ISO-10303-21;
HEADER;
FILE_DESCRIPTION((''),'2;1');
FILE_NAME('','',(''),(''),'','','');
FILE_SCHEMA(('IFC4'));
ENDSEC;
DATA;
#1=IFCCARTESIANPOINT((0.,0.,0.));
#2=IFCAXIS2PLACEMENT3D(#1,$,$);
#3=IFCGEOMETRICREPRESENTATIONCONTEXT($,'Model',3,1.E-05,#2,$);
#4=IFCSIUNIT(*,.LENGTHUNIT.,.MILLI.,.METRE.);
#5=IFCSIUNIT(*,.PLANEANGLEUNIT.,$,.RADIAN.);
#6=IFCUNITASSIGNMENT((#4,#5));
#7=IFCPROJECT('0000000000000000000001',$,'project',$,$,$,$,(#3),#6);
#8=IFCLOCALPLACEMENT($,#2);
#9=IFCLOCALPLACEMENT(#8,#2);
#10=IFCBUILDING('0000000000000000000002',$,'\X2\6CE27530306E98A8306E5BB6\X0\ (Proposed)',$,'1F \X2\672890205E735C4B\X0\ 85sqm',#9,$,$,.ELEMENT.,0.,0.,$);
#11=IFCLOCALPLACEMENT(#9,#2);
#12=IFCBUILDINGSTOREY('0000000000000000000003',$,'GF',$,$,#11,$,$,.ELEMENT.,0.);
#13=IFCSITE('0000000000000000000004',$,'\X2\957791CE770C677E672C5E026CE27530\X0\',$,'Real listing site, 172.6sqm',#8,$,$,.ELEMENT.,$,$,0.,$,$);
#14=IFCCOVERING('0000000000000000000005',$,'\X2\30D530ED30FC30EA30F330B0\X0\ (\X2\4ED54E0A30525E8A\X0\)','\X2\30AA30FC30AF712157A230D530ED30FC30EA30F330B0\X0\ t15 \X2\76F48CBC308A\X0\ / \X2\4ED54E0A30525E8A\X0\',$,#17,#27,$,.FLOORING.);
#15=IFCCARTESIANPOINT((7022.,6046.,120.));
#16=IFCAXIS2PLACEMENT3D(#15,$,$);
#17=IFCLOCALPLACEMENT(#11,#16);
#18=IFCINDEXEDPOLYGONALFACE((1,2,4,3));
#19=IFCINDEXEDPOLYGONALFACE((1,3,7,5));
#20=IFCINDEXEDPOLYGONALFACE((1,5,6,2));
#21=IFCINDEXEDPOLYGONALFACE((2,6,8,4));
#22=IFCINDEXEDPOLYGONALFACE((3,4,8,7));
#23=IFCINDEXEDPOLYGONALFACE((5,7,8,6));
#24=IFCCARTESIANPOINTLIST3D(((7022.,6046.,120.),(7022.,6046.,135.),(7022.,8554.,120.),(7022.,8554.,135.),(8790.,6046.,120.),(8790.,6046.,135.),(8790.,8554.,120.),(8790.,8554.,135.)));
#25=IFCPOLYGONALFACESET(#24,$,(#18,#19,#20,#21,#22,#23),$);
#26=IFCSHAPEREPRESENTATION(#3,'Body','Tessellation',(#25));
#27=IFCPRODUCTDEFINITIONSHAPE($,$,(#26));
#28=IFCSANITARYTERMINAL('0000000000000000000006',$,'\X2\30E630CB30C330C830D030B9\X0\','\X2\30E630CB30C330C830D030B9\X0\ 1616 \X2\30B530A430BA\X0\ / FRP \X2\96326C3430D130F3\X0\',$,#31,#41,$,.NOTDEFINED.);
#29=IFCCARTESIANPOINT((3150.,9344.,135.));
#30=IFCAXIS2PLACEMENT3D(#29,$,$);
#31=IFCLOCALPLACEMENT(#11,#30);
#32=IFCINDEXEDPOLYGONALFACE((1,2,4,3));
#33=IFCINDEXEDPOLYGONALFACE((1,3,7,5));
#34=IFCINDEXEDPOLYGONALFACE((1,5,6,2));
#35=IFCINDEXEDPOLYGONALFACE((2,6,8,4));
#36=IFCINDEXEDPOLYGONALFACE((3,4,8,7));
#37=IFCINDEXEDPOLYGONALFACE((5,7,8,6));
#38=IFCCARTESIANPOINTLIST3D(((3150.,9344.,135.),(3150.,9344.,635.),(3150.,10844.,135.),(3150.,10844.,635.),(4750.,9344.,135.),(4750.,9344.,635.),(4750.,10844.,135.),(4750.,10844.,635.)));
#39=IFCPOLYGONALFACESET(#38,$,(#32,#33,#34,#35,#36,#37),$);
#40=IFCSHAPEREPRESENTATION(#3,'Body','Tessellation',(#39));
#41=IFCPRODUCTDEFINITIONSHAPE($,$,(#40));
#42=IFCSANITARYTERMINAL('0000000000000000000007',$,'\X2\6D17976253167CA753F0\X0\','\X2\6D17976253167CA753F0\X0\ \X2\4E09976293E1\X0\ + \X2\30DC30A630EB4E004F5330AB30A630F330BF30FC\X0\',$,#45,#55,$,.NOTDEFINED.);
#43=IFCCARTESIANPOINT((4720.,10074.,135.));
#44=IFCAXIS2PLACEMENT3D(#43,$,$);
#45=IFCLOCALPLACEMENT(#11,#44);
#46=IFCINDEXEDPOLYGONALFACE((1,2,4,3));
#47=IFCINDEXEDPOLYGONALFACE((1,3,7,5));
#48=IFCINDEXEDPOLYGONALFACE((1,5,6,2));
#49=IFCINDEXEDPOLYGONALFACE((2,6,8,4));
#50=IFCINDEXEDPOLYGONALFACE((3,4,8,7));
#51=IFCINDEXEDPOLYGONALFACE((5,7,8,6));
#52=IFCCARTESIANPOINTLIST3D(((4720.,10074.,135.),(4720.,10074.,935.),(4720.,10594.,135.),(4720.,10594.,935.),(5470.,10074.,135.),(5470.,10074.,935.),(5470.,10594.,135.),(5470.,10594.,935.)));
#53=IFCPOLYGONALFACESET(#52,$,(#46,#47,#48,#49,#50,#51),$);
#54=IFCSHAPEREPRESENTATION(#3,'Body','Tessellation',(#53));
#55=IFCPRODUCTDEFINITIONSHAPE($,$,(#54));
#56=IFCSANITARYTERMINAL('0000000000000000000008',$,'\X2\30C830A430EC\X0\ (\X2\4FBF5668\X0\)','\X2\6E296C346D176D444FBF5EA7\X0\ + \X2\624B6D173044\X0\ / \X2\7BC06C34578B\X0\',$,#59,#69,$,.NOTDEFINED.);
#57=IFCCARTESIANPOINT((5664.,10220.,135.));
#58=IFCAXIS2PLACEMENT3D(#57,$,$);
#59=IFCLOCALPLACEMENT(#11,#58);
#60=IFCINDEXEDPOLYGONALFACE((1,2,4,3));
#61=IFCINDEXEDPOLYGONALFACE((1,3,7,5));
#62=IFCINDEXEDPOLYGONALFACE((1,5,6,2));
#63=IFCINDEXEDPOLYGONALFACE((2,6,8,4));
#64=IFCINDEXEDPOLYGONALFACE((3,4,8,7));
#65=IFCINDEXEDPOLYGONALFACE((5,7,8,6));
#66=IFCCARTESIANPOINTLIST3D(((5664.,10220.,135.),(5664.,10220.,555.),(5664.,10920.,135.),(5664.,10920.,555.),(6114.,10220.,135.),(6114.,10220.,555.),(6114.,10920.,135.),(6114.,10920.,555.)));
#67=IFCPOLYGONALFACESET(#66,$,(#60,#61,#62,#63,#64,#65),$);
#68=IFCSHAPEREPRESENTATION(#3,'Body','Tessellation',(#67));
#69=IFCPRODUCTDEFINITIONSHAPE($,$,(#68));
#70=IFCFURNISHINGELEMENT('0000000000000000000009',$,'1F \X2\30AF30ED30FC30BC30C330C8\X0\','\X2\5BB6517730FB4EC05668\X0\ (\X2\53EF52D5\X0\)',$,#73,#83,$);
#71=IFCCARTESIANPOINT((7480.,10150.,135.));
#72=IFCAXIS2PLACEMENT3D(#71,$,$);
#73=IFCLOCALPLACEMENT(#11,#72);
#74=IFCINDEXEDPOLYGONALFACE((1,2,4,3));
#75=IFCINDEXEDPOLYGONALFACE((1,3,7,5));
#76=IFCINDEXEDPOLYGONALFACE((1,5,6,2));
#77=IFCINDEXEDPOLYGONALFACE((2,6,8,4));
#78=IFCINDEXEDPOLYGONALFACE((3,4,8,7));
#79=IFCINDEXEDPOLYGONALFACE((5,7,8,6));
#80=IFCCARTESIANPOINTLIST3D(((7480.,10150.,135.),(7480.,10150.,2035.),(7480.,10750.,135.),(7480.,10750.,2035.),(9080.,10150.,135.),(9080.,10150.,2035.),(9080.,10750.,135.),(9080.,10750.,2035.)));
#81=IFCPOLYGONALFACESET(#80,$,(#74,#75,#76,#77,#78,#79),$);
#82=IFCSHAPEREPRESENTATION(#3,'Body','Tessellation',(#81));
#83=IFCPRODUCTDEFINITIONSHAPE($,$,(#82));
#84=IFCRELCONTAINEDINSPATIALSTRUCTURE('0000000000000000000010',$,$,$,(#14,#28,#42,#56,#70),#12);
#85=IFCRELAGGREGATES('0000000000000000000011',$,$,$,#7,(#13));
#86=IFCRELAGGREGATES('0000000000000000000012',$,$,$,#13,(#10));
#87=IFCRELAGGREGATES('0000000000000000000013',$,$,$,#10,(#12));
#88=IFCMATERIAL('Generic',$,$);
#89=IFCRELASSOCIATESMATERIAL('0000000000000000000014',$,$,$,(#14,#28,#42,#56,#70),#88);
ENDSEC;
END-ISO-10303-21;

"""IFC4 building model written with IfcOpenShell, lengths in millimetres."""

from ifc_helpers import new_model, si_unit, frame, frame_2d, origin, place, context, project, spatial, rectangle, extrude, material, element, save


model = new_model("IFC4")

# Units and contexts
model_context = context("Model", 3, precision=1e-05, world=origin())
ifc_project = project(units=[si_unit("LENGTHUNIT", "METRE", prefix="MILLI"), si_unit("PLANEANGLEUNIT", "RADIAN")], contexts=[model_context])

# Site, building, storey
site_placement = place(None, origin())
site = spatial("IfcSite", under=ifc_project, at=site_placement, Name="長野県松本市波田", ObjectType="Real listing site, 172.6sqm", CompositionType="ELEMENT", RefElevation=0.0)
building_placement = place(site_placement, origin())
building = spatial("IfcBuilding", under=site, at=building_placement, Name="波田の風の家 (Proposed)", ObjectType="1F 木造平屋 85sqm", CompositionType="ELEMENT", ElevationOfRefHeight=0.0, ElevationOfTerrain=0.0)
storey_placement = place(building_placement, origin())
storey = spatial("IfcBuildingStorey", under=building, at=storey_placement, Name="GF", CompositionType="ELEMENT", Elevation=0.0)

# Covering
ifc_material_1 = material(Name="Generic")
covering_1_placement = place(storey_placement, frame((7022.0, 6046.0, 120.0)))
element("IfcCovering", 1, at=covering_1_placement, inside=storey, material=ifc_material_1, Name="フローリング (仕上げ床)", Description="オーク無垢フローリング t15 直貼り / 仕上げ床", PredefinedType="FLOORING", context=model_context, shape_type="SweptSolid", body=[
    extrude(rectangle(XDim=1768.0, YDim=2508.0, at=frame_2d((884.0, 1254.0))), frame((7022.0, 6046.0, 120.0)), (0.0, 0.0, 1.0), 15.0),
])

# Sanitary terminals
sanitary_terminal_1_placement = place(storey_placement, frame((3150.0, 9344.0, 135.0)))
element("IfcSanitaryTerminal", 2, at=sanitary_terminal_1_placement, inside=storey, material=ifc_material_1, Name="ユニットバス", Description="ユニットバス 1616 サイズ / FRP 防水パン", PredefinedType="NOTDEFINED", context=model_context, shape_type="SweptSolid", body=[
    extrude(rectangle(XDim=1600.0, YDim=1500.0, at=frame_2d((800.0, 750.0))), frame((3150.0, 9344.0, 135.0)), (0.0, 0.0, 1.0), 500.0),
])
sanitary_terminal_2_placement = place(storey_placement, frame((4720.0, 10074.0, 135.0)))
element("IfcSanitaryTerminal", 3, at=sanitary_terminal_2_placement, inside=storey, material=ifc_material_1, Name="洗面化粧台", Description="洗面化粧台 三面鏡 + ボウル一体カウンター", PredefinedType="NOTDEFINED", context=model_context, shape_type="SweptSolid", body=[
    extrude(rectangle(XDim=750.0, YDim=520.0, at=frame_2d((375.0, 260.0))), frame((4720.0, 10074.0, 135.0)), (0.0, 0.0, 1.0), 800.0),
])
sanitary_terminal_3_placement = place(storey_placement, frame((5664.0, 10220.0, 135.0)))
element("IfcSanitaryTerminal", 4, at=sanitary_terminal_3_placement, inside=storey, material=ifc_material_1, Name="トイレ (便器)", Description="温水洗浄便座 + 手洗い / 節水型", PredefinedType="NOTDEFINED", context=model_context, shape_type="SweptSolid", body=[
    extrude(rectangle(XDim=450.0, YDim=700.0, at=frame_2d((225.0, 350.0))), frame((5664.0, 10220.0, 135.0)), (0.0, 0.0, 1.0), 420.0),
])

# Furnishing element
furnishing_placement = place(storey_placement, frame((7480.0, 10150.0, 135.0)))
element("IfcFurnishingElement", 5, at=furnishing_placement, inside=storey, material=ifc_material_1, Name="1F クローゼット", Description="家具・什器 (可動)", context=model_context, shape_type="SweptSolid", body=[
    extrude(rectangle(XDim=1600.0, YDim=600.0, at=frame_2d((800.0, 300.0))), frame((7480.0, 10150.0, 135.0)), (0.0, 0.0, 1.0), 1900.0),
])

save(model, "model.ifc")
